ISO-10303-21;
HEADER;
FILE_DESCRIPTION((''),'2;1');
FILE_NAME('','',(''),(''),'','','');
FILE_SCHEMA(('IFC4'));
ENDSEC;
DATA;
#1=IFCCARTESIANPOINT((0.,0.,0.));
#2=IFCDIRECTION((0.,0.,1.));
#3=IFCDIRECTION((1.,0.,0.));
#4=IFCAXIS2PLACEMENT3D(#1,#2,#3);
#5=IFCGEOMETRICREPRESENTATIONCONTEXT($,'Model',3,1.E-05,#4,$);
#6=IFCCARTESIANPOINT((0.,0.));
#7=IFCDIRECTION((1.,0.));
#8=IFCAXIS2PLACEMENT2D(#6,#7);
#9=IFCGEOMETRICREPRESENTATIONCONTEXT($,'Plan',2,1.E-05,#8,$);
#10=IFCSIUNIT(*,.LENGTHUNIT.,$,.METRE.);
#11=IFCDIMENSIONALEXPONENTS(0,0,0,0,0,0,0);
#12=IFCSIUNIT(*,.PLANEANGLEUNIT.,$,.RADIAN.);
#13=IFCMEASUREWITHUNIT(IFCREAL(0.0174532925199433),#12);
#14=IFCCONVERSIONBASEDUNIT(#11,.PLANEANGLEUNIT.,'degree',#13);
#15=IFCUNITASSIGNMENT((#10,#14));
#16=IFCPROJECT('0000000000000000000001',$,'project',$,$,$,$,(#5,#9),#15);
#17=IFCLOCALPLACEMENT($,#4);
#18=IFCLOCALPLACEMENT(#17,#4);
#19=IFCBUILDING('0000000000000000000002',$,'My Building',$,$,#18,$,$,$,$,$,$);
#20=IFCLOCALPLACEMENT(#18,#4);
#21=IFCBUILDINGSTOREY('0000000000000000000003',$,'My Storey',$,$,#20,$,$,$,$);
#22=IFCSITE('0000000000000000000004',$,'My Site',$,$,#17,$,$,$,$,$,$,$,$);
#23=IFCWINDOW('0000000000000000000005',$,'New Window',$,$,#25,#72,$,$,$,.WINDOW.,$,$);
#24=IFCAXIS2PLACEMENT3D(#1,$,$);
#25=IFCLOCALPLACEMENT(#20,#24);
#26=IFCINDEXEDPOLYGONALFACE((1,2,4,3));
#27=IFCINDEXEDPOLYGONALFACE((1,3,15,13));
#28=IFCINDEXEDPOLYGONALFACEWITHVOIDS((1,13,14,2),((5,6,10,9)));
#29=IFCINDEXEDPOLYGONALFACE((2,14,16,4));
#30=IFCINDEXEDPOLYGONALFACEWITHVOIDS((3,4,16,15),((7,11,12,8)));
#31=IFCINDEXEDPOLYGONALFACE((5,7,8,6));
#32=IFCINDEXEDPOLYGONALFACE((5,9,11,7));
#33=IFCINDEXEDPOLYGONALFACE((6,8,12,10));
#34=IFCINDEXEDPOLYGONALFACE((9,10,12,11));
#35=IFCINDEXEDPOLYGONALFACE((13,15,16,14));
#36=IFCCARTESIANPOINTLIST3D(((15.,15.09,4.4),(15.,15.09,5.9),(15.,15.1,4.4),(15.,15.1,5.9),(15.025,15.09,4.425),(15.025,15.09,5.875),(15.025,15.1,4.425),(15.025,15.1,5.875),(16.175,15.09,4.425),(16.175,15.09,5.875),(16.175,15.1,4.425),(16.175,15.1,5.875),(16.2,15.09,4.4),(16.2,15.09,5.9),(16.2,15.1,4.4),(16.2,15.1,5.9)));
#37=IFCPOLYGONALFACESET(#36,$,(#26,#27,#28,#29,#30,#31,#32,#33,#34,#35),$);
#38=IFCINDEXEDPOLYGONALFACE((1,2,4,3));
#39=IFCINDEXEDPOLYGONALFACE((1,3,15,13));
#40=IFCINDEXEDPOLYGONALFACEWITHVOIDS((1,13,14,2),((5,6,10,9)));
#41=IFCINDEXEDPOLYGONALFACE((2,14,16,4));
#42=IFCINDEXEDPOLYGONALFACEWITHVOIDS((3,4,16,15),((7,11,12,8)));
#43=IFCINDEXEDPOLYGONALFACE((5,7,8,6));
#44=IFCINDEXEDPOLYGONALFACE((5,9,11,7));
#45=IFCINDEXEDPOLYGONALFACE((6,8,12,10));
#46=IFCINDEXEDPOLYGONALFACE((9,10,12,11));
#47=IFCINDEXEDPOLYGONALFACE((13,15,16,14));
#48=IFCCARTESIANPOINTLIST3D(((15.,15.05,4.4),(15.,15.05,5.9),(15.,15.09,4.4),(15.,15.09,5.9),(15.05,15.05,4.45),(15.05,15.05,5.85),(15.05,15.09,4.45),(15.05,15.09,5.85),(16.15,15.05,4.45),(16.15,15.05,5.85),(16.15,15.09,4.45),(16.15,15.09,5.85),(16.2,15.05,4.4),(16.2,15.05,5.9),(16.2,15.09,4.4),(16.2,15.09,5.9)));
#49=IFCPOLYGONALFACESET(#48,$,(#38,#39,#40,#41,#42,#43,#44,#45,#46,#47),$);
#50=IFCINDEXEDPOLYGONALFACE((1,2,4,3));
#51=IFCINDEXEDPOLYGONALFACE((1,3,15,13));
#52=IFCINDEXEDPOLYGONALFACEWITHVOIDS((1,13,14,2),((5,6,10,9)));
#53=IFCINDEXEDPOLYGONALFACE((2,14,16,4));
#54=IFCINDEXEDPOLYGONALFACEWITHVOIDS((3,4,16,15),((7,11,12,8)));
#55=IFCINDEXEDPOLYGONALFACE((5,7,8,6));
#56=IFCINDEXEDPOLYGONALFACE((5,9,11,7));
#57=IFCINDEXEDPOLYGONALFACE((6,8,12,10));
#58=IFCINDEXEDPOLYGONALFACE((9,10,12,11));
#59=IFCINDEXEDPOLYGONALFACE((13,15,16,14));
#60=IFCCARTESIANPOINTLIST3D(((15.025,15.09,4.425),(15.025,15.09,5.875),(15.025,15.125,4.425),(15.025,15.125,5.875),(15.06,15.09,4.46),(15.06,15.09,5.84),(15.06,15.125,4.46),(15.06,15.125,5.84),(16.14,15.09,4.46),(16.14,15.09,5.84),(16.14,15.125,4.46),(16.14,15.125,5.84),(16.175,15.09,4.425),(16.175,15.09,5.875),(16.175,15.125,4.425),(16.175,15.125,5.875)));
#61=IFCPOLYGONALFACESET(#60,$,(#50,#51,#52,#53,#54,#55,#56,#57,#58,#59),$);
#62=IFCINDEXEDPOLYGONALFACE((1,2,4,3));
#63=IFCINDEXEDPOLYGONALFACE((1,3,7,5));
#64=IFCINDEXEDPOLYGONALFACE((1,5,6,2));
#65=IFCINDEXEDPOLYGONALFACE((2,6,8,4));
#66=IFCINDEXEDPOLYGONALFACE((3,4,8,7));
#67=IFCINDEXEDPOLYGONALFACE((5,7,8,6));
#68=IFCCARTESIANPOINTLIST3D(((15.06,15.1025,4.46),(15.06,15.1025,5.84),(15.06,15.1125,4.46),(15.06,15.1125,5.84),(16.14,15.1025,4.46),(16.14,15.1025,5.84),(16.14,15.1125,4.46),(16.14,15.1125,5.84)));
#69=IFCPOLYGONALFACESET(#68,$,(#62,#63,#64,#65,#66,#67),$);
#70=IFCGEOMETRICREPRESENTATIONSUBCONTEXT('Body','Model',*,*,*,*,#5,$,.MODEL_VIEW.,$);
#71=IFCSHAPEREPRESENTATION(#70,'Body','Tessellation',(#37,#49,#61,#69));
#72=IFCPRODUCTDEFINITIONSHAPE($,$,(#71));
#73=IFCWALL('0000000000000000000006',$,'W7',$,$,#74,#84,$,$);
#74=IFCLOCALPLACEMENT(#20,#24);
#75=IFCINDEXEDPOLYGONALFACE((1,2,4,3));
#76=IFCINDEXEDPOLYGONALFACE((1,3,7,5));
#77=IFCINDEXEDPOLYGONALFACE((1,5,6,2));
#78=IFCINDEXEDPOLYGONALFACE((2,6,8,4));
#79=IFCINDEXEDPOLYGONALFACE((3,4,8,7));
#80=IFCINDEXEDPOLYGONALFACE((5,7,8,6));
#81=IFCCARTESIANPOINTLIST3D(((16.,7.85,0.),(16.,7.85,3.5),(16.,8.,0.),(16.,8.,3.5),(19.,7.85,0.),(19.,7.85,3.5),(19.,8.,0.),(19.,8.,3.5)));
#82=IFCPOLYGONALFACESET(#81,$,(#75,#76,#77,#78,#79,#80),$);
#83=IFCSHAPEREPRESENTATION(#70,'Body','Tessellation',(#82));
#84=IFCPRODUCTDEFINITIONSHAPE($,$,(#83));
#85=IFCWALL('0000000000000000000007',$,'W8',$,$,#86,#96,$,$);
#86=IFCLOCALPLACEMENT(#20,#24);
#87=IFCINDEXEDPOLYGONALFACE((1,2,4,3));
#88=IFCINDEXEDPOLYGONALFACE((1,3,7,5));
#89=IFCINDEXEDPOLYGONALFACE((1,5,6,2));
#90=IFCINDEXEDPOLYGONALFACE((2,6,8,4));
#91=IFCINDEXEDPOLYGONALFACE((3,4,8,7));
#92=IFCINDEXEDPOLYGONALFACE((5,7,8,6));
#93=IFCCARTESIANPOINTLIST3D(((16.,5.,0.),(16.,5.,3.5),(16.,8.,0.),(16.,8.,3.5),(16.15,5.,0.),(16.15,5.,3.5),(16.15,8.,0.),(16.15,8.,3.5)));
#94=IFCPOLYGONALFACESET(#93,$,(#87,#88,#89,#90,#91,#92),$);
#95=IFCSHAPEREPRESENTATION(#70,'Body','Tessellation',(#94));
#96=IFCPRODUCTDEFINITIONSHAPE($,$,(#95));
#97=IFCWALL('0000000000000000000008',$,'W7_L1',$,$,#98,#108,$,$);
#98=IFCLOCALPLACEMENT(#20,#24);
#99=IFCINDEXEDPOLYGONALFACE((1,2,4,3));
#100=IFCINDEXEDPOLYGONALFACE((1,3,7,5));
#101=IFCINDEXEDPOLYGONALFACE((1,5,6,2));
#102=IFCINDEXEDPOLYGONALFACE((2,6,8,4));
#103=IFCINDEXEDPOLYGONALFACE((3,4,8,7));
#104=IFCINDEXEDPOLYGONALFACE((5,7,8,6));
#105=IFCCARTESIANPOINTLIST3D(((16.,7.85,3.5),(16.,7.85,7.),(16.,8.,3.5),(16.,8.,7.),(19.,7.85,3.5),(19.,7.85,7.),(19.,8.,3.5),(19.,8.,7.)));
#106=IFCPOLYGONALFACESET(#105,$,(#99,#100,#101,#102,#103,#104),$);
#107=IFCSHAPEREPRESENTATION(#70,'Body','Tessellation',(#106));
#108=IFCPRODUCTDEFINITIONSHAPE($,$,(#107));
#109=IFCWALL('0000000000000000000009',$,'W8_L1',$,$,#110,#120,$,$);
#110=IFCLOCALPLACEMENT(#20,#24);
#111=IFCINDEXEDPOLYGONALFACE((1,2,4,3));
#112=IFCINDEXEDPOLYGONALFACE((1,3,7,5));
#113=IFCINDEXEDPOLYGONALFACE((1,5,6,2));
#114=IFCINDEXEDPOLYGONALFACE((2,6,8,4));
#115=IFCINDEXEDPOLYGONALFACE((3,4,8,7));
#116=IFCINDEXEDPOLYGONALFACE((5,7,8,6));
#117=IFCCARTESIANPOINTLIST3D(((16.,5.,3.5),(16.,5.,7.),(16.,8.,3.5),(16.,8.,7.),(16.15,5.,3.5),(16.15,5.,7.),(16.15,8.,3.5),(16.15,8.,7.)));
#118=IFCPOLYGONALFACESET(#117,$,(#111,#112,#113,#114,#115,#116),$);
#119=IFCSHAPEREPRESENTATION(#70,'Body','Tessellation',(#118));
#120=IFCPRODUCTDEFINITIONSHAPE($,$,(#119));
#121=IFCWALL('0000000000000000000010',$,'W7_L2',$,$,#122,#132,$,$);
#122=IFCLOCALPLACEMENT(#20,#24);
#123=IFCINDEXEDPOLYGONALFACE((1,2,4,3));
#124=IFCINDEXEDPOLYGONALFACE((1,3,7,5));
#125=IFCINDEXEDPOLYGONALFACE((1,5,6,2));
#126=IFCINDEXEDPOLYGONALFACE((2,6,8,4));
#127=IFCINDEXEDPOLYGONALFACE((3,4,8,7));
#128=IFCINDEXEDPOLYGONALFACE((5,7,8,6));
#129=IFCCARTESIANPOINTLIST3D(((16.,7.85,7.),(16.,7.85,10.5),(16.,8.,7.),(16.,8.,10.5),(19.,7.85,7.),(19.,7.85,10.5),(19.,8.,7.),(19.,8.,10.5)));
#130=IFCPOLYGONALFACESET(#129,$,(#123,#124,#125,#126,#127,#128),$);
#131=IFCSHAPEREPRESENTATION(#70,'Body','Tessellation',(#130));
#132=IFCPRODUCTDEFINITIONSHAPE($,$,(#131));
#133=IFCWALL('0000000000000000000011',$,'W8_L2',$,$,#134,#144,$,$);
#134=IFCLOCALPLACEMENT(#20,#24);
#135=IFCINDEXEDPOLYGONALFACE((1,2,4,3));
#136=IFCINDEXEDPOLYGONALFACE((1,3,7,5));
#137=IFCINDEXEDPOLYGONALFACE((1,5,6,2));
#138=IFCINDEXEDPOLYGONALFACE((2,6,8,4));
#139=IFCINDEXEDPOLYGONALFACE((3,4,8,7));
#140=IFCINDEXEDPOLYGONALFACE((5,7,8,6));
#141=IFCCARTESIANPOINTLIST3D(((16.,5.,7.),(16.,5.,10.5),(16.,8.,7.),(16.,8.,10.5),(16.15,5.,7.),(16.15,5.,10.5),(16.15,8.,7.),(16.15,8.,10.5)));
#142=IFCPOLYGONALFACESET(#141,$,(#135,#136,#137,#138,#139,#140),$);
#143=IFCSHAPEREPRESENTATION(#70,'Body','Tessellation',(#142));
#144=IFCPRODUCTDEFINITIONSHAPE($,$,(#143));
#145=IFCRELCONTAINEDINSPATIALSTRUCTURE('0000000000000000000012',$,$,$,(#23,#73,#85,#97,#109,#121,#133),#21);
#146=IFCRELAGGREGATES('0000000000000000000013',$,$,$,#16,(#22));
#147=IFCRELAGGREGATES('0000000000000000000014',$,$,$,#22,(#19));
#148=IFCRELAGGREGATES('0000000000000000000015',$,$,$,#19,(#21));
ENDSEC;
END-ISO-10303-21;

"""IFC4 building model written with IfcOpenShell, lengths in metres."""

from ifc_helpers import new_model, entity, si_unit, converted_unit, frame, origin_with_axes, origin_2d_with_axis, place, context, subcontext, project, spatial, line, indexed_curve, outline, extrude, element, save


model = new_model("IFC4")

# Units and contexts
model_context = context("Model", 3, precision=1e-05, world=origin_with_axes())
plan_context = context("Plan", 2, precision=1e-05, world=origin_2d_with_axis())
body_context = subcontext(model_context, "Body", "Model", "MODEL_VIEW")
ifc_project = project(units=[si_unit("LENGTHUNIT", "METRE"), converted_unit("PLANEANGLEUNIT", "degree", entity("IfcReal", 0.0174532925199433), si_unit("PLANEANGLEUNIT", "RADIAN"), dimensions=[0, 0, 0, 0, 0, 0, 0])], contexts=[model_context, plan_context])

# Site, building, storey
site_placement = place(None, origin_with_axes())
site = spatial("IfcSite", under=ifc_project, at=site_placement, Name="My Site")
building_placement = place(site_placement, origin_with_axes())
building = spatial("IfcBuilding", under=site, at=building_placement, Name="My Building")
storey_placement = place(building_placement, origin_with_axes())
storey = spatial("IfcBuildingStorey", under=building, at=storey_placement, Name="My Storey")

# Window
for number, where, z_axis, x_axis, name in (
    (1, (15.0, 15.0, 4.4), (0.0, 0.0, 1.0), (1.0, 0.0, 0.0), "New Window"),
):
    element("IfcWindow", number, at=place(storey_placement, frame(where, z_axis=z_axis, x_axis=x_axis)), inside=storey, Name=name, PredefinedType="WINDOW", context=body_context, shape_type="SweptSolid", body=[
        extrude(outline(indexed_curve([(0.0, 0.0), (1.2, 0.0), (1.2, 1.5), (0.0, 1.5)], segments=[line(1, 2, 3, 4, 1)]), holes=[indexed_curve([(0.025, 0.025), (1.175, 0.025), (1.175, 1.475), (0.025, 1.475)], segments=[line(1, 2, 3, 4, 1)])]), frame((0.0, 0.09, 0.0), z_axis=(0.0, -1.0, 0.0), x_axis=(1.0, 0.0, 0.0)), (0.0, 0.0, -1.0), 0.01),
        extrude(outline(indexed_curve([(0.0, 0.0), (1.2, 0.0), (1.2, 1.5), (0.0, 1.5)], segments=[line(1, 2, 3, 4, 1)]), holes=[indexed_curve([(0.05, 0.05), (1.15, 0.05), (1.15, 1.45), (0.05, 1.45)], segments=[line(1, 2, 3, 4, 1)])]), frame((0.0, 0.05, 0.0), z_axis=(0.0, -1.0, 0.0), x_axis=(1.0, 0.0, 0.0)), (0.0, 0.0, -1.0), 0.04),
        extrude(outline(indexed_curve([(0.0, 0.0), (1.15, 0.0), (1.15, 1.45), (0.0, 1.45)], segments=[line(1, 2, 3, 4, 1)]), holes=[indexed_curve([(0.035, 0.035), (1.115, 0.035), (1.115, 1.415), (0.035, 1.415)], segments=[line(1, 2, 3, 4, 1)])]), frame((0.025, 0.09, 0.025), z_axis=(0.0, -1.0, 0.0), x_axis=(1.0, 0.0, 0.0)), (0.0, 0.0, -1.0), 0.035),
        extrude(outline(indexed_curve([(0.035, 0.035), (1.115, 0.035), (1.115, 1.415), (0.035, 1.415)], segments=[line(1, 2, 3, 4, 1)])), frame((0.025, 0.1025, 0.025), z_axis=(0.0, -1.0, 0.0), x_axis=(1.0, 0.0, 0.0)), (0.0, 0.0, -1.0), 0.01),
    ])

# Walls
for number, where, z_axis, x_axis, name in (
    (2, (19.0, 8.0, 0.0), (0.0, 0.0, 1.0), (-1.0, 0.0, 0.0), "W7"),
    (3, (16.0, 8.0, 0.0), (0.0, 0.0, 1.0), (0.0, -1.0, 0.0), "W8"),
):
    element("IfcWall", number, at=place(storey_placement, frame(where, z_axis=z_axis, x_axis=x_axis)), inside=storey, Name=name, context=body_context, shape_type="SweptSolid", body=[
        extrude(outline(indexed_curve([(0.0, 0.0), (0.0, 0.15), (3.0, 0.15), (3.0, 0.0), (0.0, 0.0)], self_intersect=False)), origin_with_axes(), (0.0, 0.0, 1.0), 3.5),
    ])
for number, where, z_axis, x_axis, name in (
    (4, (19.0, 8.0, 3.5), (0.0, 0.0, 1.0), (-1.0, 0.0, 0.0), "W7_L1"),
    (5, (16.0, 8.0, 3.5), (0.0, 0.0, 1.0), (0.0, -1.0, 0.0), "W8_L1"),
):
    element("IfcWall", number, at=place(storey_placement, frame(where, z_axis=z_axis, x_axis=x_axis)), inside=storey, Name=name, context=body_context, shape_type="SweptSolid", body=[
        extrude(outline(indexed_curve([(0.0, 0.0), (0.0, 0.15), (3.0, 0.15), (3.0, 0.0), (0.0, 0.0)], self_intersect=False)), origin_with_axes(), (0.0, 0.0, 1.0), 3.5),
    ])
for number, where, z_axis, x_axis, name in (
    (6, (19.0, 8.0, 7.0), (0.0, 0.0, 1.0), (-1.0, 0.0, 0.0), "W7_L2"),
    (7, (16.0, 8.0, 7.0), (0.0, 0.0, 1.0), (0.0, -1.0, 0.0), "W8_L2"),
):
    element("IfcWall", number, at=place(storey_placement, frame(where, z_axis=z_axis, x_axis=x_axis)), inside=storey, Name=name, context=body_context, shape_type="SweptSolid", body=[
        extrude(outline(indexed_curve([(0.0, 0.0), (0.0, 0.15), (3.0, 0.15), (3.0, 0.0), (0.0, 0.0)], self_intersect=False)), origin_with_axes(), (0.0, 0.0, 1.0), 3.5),
    ])

save(model, "model.ifc")
